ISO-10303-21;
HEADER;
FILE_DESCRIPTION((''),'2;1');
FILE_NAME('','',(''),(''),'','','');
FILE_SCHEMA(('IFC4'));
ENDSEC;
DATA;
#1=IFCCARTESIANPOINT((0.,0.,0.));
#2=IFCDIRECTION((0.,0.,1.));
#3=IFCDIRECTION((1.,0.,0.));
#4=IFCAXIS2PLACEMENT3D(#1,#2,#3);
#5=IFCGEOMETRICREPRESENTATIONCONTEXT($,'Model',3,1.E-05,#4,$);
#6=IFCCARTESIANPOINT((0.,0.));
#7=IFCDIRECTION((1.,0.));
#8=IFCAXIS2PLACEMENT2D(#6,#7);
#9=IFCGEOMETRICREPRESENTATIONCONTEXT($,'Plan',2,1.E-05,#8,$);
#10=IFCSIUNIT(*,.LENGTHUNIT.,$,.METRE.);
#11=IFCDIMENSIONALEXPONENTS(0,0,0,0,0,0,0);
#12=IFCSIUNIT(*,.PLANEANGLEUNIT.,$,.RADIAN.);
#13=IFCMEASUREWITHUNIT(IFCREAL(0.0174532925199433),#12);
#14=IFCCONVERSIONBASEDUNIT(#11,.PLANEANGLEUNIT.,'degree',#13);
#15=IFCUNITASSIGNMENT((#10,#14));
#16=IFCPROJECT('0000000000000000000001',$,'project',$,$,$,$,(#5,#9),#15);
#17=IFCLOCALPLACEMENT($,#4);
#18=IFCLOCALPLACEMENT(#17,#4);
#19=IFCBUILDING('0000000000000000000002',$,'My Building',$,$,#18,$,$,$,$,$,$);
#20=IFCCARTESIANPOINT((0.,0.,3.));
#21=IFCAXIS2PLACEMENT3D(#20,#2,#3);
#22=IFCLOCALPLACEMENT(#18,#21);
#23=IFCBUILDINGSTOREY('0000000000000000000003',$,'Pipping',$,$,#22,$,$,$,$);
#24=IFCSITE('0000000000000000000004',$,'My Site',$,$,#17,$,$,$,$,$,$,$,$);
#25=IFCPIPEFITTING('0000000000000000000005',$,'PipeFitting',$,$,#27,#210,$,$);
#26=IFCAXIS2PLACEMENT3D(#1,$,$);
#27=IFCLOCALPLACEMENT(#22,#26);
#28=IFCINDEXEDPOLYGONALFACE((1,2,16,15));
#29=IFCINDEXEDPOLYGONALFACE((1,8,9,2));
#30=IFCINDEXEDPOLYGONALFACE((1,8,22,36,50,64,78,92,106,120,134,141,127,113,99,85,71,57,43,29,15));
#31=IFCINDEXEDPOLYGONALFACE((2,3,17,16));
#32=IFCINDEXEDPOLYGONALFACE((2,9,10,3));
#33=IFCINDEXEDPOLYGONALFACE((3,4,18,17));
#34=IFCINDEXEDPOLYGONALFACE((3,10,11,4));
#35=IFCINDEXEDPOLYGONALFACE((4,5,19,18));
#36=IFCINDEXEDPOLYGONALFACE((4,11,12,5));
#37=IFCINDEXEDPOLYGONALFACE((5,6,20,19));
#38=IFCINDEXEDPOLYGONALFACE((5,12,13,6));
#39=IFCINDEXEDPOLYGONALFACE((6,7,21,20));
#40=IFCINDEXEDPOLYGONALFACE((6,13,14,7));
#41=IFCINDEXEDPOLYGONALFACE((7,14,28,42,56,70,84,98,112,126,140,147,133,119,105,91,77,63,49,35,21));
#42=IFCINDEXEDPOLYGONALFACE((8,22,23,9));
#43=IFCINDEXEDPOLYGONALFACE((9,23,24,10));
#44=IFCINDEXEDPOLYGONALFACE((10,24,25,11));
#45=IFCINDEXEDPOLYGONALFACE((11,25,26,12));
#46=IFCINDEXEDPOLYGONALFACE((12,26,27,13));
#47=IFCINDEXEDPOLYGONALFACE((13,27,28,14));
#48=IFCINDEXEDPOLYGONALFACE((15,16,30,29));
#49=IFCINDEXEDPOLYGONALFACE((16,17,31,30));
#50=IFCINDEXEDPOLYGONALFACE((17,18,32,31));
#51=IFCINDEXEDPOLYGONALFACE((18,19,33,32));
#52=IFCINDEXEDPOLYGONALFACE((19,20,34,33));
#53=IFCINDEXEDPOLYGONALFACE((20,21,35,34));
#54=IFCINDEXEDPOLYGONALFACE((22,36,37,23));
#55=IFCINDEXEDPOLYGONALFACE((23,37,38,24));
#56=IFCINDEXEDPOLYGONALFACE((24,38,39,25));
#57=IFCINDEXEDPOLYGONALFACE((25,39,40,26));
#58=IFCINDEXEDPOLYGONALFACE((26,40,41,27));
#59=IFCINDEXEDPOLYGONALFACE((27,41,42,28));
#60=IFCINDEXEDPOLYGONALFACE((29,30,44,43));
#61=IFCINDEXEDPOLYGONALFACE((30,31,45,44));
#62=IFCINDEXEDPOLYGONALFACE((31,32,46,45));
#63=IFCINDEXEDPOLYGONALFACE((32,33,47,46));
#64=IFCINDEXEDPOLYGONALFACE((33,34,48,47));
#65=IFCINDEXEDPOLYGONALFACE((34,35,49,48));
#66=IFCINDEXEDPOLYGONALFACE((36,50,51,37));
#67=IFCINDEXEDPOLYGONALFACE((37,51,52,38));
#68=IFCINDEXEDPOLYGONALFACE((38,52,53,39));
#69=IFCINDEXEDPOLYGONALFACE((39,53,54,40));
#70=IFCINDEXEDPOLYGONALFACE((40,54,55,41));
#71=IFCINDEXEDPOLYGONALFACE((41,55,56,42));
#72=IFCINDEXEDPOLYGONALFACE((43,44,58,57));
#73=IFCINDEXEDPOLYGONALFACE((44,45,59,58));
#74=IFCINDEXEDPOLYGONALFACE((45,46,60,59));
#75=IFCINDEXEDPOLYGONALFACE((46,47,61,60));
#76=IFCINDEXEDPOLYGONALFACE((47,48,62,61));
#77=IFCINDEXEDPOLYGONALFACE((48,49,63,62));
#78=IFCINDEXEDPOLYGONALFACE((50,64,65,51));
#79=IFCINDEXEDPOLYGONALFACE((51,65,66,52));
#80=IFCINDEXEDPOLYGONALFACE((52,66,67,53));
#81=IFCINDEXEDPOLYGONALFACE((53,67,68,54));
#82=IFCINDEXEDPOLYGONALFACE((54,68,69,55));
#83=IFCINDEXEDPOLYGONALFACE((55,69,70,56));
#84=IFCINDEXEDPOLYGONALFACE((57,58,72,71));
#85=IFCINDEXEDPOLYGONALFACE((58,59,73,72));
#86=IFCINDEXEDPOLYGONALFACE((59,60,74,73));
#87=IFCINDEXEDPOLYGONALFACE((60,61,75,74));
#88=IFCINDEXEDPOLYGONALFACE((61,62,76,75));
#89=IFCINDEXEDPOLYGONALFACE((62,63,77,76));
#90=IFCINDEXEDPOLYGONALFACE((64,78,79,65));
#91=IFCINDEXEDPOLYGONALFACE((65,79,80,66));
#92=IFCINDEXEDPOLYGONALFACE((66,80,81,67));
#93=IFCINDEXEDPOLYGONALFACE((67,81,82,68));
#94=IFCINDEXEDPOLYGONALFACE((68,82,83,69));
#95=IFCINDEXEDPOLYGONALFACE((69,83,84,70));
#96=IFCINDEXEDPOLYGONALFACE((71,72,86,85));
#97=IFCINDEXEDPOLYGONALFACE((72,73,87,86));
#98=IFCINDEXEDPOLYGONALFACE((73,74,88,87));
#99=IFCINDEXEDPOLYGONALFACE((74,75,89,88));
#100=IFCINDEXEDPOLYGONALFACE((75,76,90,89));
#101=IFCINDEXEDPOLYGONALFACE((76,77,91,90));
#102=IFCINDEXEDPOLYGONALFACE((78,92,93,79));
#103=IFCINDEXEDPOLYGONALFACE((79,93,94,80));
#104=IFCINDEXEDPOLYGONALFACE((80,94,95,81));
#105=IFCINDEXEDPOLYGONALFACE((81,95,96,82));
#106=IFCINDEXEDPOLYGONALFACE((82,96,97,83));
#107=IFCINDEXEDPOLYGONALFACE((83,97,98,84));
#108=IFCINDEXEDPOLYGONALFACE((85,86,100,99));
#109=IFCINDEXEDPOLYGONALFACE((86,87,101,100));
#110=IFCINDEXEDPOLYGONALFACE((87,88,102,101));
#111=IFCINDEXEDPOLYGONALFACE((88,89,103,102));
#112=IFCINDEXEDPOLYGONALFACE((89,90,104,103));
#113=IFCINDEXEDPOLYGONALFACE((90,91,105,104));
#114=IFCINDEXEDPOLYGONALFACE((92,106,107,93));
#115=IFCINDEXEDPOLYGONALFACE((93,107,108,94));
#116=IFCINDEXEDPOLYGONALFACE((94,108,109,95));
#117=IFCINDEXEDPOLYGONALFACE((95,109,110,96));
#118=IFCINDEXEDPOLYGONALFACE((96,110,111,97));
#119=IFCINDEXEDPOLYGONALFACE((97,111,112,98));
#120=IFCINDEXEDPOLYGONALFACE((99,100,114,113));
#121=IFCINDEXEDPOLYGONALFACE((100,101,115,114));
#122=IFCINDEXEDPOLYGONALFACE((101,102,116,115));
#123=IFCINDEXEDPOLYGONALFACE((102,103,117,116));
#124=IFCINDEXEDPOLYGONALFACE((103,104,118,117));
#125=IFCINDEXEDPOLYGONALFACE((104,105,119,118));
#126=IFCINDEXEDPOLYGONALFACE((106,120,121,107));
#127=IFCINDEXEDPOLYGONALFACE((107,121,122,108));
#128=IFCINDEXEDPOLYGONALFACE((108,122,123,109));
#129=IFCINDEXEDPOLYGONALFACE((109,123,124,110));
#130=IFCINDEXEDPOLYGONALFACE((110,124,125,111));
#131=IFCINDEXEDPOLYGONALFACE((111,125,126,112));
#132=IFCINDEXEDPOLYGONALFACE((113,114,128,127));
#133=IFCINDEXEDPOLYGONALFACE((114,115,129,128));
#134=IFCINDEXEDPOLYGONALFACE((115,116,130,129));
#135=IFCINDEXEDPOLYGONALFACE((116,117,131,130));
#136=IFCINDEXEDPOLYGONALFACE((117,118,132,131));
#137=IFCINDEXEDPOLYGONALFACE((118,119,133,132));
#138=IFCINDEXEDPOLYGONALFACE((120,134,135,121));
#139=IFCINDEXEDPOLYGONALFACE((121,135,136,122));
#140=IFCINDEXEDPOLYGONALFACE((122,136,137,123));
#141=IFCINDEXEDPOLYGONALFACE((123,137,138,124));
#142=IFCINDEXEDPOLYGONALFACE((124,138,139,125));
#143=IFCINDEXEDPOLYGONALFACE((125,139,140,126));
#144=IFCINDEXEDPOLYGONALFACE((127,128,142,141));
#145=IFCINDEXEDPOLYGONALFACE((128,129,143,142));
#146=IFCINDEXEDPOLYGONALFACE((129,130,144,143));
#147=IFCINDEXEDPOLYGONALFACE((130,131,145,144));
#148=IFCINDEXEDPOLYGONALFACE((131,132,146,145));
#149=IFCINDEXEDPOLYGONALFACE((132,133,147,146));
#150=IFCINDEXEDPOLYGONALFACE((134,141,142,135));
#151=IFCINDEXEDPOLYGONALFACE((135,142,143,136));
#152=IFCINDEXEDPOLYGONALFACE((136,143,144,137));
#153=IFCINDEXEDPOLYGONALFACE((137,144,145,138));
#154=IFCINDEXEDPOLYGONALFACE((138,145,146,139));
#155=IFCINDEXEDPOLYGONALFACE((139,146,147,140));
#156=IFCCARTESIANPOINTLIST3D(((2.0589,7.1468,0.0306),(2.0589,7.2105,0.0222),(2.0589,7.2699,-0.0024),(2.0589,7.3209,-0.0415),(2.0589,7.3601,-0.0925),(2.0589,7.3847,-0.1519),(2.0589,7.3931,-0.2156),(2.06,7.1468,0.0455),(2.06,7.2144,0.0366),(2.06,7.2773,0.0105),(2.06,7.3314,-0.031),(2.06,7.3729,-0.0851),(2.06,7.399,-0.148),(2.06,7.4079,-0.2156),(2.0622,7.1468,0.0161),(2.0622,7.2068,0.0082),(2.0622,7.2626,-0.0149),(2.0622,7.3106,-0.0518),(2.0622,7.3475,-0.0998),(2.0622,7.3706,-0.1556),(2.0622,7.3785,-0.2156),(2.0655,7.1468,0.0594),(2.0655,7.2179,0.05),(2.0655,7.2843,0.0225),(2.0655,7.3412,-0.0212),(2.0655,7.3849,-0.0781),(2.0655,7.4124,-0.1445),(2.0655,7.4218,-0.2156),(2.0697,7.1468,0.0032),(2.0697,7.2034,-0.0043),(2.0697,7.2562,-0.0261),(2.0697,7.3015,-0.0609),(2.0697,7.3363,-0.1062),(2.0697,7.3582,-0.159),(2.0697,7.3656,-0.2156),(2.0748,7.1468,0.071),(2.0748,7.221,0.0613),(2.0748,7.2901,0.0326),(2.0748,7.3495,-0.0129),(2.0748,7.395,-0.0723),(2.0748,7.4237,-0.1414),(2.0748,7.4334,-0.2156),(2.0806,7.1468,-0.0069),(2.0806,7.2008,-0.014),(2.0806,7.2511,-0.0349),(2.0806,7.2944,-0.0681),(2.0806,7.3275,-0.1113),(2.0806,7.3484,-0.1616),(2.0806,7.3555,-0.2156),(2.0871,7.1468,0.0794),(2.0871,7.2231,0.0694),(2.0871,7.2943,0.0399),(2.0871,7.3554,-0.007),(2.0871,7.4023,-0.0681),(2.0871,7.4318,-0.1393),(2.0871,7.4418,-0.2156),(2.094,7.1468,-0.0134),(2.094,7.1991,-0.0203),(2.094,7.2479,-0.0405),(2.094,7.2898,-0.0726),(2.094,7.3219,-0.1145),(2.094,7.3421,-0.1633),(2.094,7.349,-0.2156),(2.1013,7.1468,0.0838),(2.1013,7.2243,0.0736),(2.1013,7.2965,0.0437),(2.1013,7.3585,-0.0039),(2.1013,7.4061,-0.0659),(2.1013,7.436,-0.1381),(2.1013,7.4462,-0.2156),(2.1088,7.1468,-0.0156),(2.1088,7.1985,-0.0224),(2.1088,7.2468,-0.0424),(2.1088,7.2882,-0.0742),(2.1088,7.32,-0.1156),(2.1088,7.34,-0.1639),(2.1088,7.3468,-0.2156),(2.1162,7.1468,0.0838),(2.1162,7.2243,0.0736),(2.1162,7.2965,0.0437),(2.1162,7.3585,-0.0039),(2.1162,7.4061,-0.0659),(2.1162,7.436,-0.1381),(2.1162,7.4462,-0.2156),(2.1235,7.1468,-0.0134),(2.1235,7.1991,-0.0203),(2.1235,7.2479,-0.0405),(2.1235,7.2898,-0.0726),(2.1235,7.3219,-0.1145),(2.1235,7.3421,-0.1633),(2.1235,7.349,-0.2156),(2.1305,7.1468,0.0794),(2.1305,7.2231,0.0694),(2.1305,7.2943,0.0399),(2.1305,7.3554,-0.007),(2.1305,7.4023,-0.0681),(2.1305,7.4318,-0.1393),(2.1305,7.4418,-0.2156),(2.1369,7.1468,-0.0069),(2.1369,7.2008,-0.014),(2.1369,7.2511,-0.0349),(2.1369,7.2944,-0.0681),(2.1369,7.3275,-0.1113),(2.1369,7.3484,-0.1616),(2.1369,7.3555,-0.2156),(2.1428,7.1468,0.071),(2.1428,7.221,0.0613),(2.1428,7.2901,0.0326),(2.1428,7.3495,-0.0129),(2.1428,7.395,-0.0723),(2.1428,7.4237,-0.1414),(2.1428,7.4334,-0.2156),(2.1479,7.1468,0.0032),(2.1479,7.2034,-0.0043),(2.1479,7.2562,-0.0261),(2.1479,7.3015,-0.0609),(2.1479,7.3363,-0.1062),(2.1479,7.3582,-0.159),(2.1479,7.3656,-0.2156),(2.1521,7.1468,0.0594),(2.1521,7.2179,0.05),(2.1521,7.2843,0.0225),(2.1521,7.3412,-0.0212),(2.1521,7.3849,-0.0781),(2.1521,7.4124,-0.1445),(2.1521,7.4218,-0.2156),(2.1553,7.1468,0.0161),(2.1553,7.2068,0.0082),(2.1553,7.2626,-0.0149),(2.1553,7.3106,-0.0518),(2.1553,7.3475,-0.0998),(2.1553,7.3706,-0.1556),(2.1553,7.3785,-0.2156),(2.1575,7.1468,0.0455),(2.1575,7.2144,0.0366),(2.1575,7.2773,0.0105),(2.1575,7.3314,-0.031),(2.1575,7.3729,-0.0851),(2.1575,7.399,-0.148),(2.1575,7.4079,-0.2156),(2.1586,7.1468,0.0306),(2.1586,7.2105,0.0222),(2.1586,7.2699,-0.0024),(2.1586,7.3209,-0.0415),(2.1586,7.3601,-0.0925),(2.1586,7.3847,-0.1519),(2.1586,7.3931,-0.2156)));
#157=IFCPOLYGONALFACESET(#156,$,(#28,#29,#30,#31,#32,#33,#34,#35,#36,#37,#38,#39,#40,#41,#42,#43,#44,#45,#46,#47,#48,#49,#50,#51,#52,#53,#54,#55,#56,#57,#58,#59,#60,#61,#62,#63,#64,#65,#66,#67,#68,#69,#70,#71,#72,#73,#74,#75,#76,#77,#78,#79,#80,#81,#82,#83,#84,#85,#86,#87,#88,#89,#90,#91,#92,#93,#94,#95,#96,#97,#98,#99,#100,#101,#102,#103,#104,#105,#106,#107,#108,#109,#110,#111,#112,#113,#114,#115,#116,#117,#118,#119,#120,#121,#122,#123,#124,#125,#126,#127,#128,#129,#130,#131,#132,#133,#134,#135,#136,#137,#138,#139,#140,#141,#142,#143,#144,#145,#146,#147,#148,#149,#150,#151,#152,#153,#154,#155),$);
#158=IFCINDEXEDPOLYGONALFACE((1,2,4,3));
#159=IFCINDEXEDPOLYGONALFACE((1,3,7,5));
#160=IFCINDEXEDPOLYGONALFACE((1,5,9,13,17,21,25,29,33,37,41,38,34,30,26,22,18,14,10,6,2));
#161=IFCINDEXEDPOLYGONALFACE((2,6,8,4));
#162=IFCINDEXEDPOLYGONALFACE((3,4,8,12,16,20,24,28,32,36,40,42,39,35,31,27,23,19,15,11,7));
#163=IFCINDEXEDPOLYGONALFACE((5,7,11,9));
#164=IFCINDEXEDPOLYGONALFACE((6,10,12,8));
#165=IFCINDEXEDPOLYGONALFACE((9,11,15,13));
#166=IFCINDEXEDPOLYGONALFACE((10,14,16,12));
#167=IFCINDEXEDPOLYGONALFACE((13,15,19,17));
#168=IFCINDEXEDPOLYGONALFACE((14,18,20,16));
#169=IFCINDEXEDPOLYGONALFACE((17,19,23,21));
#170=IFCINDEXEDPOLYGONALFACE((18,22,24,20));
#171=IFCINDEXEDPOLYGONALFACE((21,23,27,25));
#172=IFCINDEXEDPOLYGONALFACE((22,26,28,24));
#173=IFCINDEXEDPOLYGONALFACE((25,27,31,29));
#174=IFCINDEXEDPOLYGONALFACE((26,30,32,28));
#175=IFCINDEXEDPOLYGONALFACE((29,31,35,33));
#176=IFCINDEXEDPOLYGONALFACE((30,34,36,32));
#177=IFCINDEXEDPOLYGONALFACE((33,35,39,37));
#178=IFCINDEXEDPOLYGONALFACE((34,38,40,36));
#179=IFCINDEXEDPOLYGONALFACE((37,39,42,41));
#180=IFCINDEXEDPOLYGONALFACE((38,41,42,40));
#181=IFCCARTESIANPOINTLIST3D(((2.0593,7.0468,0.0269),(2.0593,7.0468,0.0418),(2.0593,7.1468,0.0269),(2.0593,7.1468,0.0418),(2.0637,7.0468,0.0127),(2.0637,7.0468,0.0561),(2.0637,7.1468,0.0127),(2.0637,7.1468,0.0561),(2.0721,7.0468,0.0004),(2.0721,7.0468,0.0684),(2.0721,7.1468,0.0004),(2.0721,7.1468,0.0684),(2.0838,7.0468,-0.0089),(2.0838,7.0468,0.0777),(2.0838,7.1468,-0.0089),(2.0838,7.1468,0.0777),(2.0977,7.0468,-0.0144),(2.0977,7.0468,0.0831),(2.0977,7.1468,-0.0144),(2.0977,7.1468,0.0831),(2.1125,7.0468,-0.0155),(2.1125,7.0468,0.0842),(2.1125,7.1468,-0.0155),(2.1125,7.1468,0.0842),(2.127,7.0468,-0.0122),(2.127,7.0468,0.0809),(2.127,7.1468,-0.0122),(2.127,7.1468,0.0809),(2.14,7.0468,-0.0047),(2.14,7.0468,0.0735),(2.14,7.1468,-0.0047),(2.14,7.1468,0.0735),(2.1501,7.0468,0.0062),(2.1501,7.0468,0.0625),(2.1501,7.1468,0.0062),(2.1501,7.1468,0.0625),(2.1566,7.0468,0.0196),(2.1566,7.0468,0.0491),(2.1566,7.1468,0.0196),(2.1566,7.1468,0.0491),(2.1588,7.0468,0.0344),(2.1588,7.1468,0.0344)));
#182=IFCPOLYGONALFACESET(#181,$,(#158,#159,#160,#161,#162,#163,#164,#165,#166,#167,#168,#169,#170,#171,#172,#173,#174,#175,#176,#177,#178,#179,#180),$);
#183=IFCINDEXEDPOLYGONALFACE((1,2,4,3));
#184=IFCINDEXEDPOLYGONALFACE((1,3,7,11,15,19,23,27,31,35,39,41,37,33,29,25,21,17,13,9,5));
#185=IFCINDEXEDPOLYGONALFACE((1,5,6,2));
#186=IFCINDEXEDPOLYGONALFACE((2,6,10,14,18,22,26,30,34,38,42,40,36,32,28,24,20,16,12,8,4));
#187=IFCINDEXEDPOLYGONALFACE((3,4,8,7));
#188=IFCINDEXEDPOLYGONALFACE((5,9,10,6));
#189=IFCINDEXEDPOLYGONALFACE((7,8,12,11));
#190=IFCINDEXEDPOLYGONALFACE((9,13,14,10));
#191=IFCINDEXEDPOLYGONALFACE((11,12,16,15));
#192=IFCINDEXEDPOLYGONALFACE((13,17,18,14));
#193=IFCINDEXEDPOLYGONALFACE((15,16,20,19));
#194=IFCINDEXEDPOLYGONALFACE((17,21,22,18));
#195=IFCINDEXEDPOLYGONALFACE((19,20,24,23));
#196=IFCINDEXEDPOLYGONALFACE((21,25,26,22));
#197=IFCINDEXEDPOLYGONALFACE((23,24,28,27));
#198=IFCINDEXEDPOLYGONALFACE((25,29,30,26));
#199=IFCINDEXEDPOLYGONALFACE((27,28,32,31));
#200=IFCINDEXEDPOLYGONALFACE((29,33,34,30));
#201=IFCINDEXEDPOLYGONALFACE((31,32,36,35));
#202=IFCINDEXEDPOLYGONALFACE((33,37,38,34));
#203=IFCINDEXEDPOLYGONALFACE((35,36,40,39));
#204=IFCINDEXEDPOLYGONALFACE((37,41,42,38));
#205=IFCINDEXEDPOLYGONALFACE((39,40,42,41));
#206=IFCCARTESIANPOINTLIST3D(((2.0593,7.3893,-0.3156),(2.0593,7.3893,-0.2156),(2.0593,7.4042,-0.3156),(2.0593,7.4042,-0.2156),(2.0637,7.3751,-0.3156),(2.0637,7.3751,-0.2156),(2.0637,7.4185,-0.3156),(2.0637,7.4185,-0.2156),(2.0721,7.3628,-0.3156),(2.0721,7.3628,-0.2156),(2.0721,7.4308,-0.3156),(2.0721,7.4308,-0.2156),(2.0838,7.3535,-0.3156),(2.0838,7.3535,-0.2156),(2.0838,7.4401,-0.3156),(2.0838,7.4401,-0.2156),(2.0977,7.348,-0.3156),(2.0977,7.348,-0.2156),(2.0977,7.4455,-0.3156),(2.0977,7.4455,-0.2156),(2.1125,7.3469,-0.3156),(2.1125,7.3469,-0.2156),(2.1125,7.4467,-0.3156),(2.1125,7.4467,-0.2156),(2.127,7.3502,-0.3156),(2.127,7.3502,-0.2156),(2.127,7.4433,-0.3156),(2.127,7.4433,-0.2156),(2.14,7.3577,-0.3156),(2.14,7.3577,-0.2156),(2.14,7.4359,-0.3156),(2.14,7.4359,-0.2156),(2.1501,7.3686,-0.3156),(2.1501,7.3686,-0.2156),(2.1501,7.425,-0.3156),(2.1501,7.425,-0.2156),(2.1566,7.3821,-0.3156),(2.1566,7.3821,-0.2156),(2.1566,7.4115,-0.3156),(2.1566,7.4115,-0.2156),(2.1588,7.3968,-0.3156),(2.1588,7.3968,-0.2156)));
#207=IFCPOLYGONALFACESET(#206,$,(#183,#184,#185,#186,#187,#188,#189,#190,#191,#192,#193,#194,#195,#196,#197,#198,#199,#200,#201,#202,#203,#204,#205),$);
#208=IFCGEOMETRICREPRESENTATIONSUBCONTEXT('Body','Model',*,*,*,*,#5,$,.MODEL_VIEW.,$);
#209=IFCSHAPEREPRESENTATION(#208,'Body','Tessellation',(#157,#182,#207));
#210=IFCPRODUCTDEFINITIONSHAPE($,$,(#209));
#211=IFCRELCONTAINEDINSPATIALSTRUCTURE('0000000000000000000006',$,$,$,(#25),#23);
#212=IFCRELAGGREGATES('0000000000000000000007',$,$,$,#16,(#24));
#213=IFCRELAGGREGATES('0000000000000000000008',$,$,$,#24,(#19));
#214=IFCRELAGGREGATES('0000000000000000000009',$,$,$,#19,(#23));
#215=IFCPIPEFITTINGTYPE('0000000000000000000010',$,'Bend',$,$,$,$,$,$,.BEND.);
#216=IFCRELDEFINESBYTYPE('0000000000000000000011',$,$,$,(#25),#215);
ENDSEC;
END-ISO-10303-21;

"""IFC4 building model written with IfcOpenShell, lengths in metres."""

from ifc_helpers import new_model, entity, si_unit, converted_unit, frame, origin_with_axes, origin_2d_with_axis, place, context, subcontext, project, spatial, circle, extrude, source, transform, mapped, type_object, type_shapes, element, save


model = new_model("IFC4")

# Units and contexts
model_context = context("Model", 3, precision=1e-05, world=origin_with_axes())
plan_context = context("Plan", 2, precision=1e-05, world=origin_2d_with_axis())
body_context = subcontext(model_context, "Body", "Model", "MODEL_VIEW")
ifc_project = project(units=[si_unit("LENGTHUNIT", "METRE"), converted_unit("PLANEANGLEUNIT", "degree", entity("IfcReal", 0.0174532925199433), si_unit("PLANEANGLEUNIT", "RADIAN"), dimensions=[0, 0, 0, 0, 0, 0, 0])], contexts=[model_context, plan_context])

# Site, building, storey
site_placement = place(None, origin_with_axes())
site = spatial("IfcSite", under=ifc_project, at=site_placement, Name="My Site")
building_placement = place(site_placement, origin_with_axes())
building = spatial("IfcBuilding", under=site, at=building_placement, Name="My Building")
storey_placement = place(building_placement, frame((0.0, 0.0, 3.0), z_axis=(0.0, 0.0, 1.0), x_axis=(1.0, 0.0, 0.0)))
storey = spatial("IfcBuildingStorey", under=building, at=storey_placement, Name="Pipping")

# Pipe fitting
pipe_fitting_type_1 = type_object("IfcPipeFittingType", Name="Bend", PredefinedType="BEND")
shared_shape_1 = source(origin_with_axes(), body_context, "Body", "SolidModel", [
    entity("IfcSweptDiskSolid", entity("IfcIndexedPolyCurve", entity("IfcCartesianPointList3D", [[0.0, 0.0, 0.1], [0.0, 0.0732, 0.2768], [0.0, 0.25, 0.35]]), [entity("IfcArcIndex", [1, 2, 3])]), 0.05),
    extrude(circle(Radius=0.05), origin_with_axes(), (0.0, 0.0, 1.0), 0.1),
    extrude(circle(Radius=0.05), frame((0.0, 0.25, 0.35), z_axis=(0.0, 1.0, -0.000073), x_axis=(1.0, 0.0, 0.0)), (0.0, 0.0, 1.0), 0.1),
])
type_shapes(pipe_fitting_type_1, [shared_shape_1])
for number, where, z_axis, x_axis, name in (
    (1, (2.1088, 7.0468, 0.0344), (0.0, 1.0, 0.000073), (1.0, 0.0, 0.0), "PipeFitting"),
):
    element("IfcPipeFitting", number, at=place(storey_placement, frame(where, z_axis=z_axis, x_axis=x_axis)), inside=storey, type_object=pipe_fitting_type_1, Name=name, context=body_context, shape_type="MappedRepresentation", body=[
        mapped(shared_shape_1, transform((0.0, 0.0, 0.0), x_axis=(1.0, 0.0, 0.0), y_axis=(0.0, 1.0, 0.0), z_axis=(0.0, 0.0, 1.0), scale=1.0)),
    ])

save(model, "model.ifc")
